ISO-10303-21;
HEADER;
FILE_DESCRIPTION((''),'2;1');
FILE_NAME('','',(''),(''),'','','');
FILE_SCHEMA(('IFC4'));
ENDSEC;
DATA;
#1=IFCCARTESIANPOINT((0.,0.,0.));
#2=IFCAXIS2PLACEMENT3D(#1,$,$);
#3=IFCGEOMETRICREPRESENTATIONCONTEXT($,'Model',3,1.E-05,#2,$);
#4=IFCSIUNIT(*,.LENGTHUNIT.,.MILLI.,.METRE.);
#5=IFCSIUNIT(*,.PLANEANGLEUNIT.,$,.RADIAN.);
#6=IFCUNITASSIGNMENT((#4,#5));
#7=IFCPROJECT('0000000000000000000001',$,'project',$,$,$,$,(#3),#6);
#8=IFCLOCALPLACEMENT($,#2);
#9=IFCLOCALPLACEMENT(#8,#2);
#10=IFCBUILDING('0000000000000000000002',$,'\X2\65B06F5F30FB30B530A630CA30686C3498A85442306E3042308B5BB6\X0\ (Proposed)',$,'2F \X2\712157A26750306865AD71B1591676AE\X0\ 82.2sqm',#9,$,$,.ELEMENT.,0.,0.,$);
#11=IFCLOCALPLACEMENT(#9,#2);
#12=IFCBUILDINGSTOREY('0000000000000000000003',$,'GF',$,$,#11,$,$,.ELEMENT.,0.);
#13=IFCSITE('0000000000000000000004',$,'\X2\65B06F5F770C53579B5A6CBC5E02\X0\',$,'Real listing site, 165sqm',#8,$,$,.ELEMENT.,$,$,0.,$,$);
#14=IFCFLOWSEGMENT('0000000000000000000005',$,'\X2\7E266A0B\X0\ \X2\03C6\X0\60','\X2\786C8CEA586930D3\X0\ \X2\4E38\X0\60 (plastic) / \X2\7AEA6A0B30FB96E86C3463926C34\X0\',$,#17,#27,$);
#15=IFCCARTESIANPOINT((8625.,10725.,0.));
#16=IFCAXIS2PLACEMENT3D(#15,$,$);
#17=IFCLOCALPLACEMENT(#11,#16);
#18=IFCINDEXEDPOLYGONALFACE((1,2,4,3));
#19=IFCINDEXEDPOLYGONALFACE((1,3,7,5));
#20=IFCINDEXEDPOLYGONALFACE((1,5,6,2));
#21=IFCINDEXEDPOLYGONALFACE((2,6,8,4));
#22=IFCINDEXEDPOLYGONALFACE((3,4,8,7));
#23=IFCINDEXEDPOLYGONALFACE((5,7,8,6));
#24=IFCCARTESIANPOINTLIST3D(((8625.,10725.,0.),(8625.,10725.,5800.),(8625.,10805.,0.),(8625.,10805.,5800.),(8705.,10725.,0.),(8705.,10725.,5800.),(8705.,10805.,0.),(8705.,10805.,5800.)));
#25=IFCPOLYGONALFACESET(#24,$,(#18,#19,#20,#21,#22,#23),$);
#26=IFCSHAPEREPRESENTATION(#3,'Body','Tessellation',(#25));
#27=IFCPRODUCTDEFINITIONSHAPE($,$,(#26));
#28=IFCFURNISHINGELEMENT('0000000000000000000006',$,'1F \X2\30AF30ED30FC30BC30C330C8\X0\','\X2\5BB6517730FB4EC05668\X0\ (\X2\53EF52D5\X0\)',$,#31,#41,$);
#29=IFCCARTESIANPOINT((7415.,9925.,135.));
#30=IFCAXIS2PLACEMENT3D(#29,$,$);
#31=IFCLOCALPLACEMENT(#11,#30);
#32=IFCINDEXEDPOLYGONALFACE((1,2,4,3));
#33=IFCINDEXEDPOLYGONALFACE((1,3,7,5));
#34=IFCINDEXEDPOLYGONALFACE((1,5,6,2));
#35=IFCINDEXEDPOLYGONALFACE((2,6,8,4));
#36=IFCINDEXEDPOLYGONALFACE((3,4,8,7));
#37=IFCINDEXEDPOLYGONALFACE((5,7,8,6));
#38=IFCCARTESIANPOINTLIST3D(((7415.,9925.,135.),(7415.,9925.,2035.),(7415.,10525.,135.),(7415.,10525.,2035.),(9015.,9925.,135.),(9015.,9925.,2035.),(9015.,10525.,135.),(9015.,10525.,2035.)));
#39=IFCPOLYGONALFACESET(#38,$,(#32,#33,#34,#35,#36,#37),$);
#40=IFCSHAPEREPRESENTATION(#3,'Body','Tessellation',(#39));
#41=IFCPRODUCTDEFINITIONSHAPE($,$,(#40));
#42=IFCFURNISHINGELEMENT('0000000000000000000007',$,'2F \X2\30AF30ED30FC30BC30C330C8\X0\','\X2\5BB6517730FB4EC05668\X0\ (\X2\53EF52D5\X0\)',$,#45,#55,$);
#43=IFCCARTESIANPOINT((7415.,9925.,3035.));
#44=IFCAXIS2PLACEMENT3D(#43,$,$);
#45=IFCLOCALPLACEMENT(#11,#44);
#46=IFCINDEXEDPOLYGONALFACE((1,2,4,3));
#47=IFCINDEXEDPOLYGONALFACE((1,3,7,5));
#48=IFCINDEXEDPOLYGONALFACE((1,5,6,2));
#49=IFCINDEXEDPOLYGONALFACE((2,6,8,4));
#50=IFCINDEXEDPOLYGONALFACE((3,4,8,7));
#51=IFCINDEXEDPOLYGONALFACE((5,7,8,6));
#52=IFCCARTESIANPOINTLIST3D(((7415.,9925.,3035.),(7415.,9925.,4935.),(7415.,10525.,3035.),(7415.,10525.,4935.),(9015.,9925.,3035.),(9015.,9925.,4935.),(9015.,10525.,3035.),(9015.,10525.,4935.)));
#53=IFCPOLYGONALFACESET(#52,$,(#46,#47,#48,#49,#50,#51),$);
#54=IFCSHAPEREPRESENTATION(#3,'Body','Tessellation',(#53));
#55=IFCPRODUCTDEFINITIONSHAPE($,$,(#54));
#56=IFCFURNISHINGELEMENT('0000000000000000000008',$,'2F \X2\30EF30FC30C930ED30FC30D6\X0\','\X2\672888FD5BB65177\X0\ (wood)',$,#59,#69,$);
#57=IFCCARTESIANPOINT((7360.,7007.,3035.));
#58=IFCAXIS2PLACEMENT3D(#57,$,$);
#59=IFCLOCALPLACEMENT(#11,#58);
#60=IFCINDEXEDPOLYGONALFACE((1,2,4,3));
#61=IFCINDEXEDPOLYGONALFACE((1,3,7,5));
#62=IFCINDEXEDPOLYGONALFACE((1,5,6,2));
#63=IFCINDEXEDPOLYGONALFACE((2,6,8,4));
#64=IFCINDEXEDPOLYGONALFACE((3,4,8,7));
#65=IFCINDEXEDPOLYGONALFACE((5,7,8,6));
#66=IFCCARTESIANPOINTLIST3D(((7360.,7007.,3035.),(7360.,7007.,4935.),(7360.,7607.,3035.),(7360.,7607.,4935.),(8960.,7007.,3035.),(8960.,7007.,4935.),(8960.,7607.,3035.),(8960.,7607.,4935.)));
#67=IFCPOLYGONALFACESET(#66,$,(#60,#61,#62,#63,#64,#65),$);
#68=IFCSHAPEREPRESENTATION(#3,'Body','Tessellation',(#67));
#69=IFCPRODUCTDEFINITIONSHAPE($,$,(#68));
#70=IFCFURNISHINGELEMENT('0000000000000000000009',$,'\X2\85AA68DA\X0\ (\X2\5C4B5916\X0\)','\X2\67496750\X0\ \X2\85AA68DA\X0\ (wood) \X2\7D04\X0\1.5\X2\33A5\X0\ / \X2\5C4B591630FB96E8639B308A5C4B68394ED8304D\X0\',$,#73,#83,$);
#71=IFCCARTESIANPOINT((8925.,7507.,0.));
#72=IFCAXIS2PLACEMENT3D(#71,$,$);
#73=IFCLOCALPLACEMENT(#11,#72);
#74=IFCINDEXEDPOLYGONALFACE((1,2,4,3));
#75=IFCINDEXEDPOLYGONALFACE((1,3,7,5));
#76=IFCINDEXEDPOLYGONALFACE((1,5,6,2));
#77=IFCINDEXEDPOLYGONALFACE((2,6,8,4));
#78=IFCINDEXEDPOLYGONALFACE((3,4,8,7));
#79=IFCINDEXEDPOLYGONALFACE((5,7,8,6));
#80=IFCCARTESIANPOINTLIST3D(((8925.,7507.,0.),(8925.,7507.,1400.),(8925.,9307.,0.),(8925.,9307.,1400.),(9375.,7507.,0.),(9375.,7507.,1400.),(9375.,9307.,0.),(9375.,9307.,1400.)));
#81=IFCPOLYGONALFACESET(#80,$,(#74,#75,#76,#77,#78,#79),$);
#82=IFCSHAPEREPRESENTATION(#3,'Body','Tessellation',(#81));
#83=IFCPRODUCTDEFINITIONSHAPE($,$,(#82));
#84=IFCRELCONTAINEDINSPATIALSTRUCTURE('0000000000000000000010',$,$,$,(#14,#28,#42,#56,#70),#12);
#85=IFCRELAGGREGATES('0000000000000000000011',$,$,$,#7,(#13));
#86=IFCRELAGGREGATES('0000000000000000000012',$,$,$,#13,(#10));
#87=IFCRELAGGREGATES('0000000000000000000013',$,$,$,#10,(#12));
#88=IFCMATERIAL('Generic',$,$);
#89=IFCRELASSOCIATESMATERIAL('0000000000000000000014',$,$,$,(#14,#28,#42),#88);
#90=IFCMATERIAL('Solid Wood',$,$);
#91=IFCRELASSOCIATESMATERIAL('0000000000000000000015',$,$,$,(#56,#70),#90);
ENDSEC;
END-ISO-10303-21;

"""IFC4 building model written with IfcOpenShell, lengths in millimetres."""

from ifc_helpers import new_model, si_unit, frame, frame_2d, origin, place, context, project, spatial, rectangle, extrude, material, element, save


model = new_model("IFC4")

# Units and contexts
model_context = context("Model", 3, precision=1e-05, world=origin())
ifc_project = project(units=[si_unit("LENGTHUNIT", "METRE", prefix="MILLI"), si_unit("PLANEANGLEUNIT", "RADIAN")], contexts=[model_context])

# Site, building, storey
site_placement = place(None, origin())
site = spatial("IfcSite", under=ifc_project, at=site_placement, Name="新潟県南魚沼市", ObjectType="Real listing site, 165sqm", CompositionType="ELEMENT", RefElevation=0.0)
building_placement = place(site_placement, origin())
building = spatial("IfcBuilding", under=site, at=building_placement, Name="新潟・サウナと水風呂のある家 (Proposed)", ObjectType="2F 無垢材と断熱外皮 82.2sqm", CompositionType="ELEMENT", ElevationOfRefHeight=0.0, ElevationOfTerrain=0.0)
storey_placement = place(building_placement, origin())
storey = spatial("IfcBuildingStorey", under=building, at=storey_placement, Name="GF", CompositionType="ELEMENT", Elevation=0.0)

# Shared definitions
ifc_material_1 = material(Name="Solid Wood")

# Shared definitions
ifc_material_2 = material(Name="Generic")

# Flow segment
flow_segment_placement = place(storey_placement, frame((8625.0, 10725.0, 0.0)))
element("IfcFlowSegment", 1, at=flow_segment_placement, inside=storey, material=ifc_material_2, Name="縦樋 φ60", Description="硬質塩ビ 丸60 (plastic) / 竪樋・雨水排水", context=model_context, shape_type="SweptSolid", body=[
    extrude(rectangle(XDim=80.0, YDim=80.0, at=frame_2d((40.0, 40.0))), frame((8625.0, 10725.0, 0.0)), (0.0, 0.0, 1.0), 5800.0),
])

# Furnishing elements
furnishing_1_placement = place(storey_placement, frame((7415.0, 9925.0, 135.0)))
element("IfcFurnishingElement", 2, at=furnishing_1_placement, inside=storey, material=ifc_material_2, Name="1F クローゼット", Description="家具・什器 (可動)", context=model_context, shape_type="SweptSolid", body=[
    extrude(rectangle(XDim=1600.0, YDim=600.0, at=frame_2d((800.0, 300.0))), frame((7415.0, 9925.0, 135.0)), (0.0, 0.0, 1.0), 1900.0),
])
furnishing_2_placement = place(storey_placement, frame((7415.0, 9925.0, 3035.0)))
element("IfcFurnishingElement", 3, at=furnishing_2_placement, inside=storey, material=ifc_material_2, Name="2F クローゼット", Description="家具・什器 (可動)", context=model_context, shape_type="SweptSolid", body=[
    extrude(rectangle(XDim=1600.0, YDim=600.0, at=frame_2d((800.0, 300.0))), frame((7415.0, 9925.0, 3035.0)), (0.0, 0.0, 1.0), 1900.0),
])
furnishing_3_placement = place(storey_placement, frame((7360.0, 7007.0, 3035.0)))
element("IfcFurnishingElement", 4, at=furnishing_3_placement, inside=storey, material=ifc_material_1, Name="2F ワードローブ", Description="木製家具 (wood)", context=model_context, shape_type="SweptSolid", body=[
    extrude(rectangle(XDim=1600.0, YDim=600.0, at=frame_2d((800.0, 300.0))), frame((7360.0, 7007.0, 3035.0)), (0.0, 0.0, 1.0), 1900.0),
])
furnishing_4_placement = place(storey_placement, frame((8925.0, 7507.0, 0.0)))
element("IfcFurnishingElement", 5, at=furnishing_4_placement, inside=storey, material=ifc_material_1, Name="薪棚 (屋外)", Description="杉材 薪棚 (wood) 約1.5㎥ / 屋外・雨掛り屋根付き", context=model_context, shape_type="SweptSolid", body=[
    extrude(rectangle(XDim=450.0, YDim=1800.0, at=frame_2d((225.0, 900.0))), frame((8925.0, 7507.0, 0.0)), (0.0, 0.0, 1.0), 1400.0),
])

save(model, "model.ifc")
